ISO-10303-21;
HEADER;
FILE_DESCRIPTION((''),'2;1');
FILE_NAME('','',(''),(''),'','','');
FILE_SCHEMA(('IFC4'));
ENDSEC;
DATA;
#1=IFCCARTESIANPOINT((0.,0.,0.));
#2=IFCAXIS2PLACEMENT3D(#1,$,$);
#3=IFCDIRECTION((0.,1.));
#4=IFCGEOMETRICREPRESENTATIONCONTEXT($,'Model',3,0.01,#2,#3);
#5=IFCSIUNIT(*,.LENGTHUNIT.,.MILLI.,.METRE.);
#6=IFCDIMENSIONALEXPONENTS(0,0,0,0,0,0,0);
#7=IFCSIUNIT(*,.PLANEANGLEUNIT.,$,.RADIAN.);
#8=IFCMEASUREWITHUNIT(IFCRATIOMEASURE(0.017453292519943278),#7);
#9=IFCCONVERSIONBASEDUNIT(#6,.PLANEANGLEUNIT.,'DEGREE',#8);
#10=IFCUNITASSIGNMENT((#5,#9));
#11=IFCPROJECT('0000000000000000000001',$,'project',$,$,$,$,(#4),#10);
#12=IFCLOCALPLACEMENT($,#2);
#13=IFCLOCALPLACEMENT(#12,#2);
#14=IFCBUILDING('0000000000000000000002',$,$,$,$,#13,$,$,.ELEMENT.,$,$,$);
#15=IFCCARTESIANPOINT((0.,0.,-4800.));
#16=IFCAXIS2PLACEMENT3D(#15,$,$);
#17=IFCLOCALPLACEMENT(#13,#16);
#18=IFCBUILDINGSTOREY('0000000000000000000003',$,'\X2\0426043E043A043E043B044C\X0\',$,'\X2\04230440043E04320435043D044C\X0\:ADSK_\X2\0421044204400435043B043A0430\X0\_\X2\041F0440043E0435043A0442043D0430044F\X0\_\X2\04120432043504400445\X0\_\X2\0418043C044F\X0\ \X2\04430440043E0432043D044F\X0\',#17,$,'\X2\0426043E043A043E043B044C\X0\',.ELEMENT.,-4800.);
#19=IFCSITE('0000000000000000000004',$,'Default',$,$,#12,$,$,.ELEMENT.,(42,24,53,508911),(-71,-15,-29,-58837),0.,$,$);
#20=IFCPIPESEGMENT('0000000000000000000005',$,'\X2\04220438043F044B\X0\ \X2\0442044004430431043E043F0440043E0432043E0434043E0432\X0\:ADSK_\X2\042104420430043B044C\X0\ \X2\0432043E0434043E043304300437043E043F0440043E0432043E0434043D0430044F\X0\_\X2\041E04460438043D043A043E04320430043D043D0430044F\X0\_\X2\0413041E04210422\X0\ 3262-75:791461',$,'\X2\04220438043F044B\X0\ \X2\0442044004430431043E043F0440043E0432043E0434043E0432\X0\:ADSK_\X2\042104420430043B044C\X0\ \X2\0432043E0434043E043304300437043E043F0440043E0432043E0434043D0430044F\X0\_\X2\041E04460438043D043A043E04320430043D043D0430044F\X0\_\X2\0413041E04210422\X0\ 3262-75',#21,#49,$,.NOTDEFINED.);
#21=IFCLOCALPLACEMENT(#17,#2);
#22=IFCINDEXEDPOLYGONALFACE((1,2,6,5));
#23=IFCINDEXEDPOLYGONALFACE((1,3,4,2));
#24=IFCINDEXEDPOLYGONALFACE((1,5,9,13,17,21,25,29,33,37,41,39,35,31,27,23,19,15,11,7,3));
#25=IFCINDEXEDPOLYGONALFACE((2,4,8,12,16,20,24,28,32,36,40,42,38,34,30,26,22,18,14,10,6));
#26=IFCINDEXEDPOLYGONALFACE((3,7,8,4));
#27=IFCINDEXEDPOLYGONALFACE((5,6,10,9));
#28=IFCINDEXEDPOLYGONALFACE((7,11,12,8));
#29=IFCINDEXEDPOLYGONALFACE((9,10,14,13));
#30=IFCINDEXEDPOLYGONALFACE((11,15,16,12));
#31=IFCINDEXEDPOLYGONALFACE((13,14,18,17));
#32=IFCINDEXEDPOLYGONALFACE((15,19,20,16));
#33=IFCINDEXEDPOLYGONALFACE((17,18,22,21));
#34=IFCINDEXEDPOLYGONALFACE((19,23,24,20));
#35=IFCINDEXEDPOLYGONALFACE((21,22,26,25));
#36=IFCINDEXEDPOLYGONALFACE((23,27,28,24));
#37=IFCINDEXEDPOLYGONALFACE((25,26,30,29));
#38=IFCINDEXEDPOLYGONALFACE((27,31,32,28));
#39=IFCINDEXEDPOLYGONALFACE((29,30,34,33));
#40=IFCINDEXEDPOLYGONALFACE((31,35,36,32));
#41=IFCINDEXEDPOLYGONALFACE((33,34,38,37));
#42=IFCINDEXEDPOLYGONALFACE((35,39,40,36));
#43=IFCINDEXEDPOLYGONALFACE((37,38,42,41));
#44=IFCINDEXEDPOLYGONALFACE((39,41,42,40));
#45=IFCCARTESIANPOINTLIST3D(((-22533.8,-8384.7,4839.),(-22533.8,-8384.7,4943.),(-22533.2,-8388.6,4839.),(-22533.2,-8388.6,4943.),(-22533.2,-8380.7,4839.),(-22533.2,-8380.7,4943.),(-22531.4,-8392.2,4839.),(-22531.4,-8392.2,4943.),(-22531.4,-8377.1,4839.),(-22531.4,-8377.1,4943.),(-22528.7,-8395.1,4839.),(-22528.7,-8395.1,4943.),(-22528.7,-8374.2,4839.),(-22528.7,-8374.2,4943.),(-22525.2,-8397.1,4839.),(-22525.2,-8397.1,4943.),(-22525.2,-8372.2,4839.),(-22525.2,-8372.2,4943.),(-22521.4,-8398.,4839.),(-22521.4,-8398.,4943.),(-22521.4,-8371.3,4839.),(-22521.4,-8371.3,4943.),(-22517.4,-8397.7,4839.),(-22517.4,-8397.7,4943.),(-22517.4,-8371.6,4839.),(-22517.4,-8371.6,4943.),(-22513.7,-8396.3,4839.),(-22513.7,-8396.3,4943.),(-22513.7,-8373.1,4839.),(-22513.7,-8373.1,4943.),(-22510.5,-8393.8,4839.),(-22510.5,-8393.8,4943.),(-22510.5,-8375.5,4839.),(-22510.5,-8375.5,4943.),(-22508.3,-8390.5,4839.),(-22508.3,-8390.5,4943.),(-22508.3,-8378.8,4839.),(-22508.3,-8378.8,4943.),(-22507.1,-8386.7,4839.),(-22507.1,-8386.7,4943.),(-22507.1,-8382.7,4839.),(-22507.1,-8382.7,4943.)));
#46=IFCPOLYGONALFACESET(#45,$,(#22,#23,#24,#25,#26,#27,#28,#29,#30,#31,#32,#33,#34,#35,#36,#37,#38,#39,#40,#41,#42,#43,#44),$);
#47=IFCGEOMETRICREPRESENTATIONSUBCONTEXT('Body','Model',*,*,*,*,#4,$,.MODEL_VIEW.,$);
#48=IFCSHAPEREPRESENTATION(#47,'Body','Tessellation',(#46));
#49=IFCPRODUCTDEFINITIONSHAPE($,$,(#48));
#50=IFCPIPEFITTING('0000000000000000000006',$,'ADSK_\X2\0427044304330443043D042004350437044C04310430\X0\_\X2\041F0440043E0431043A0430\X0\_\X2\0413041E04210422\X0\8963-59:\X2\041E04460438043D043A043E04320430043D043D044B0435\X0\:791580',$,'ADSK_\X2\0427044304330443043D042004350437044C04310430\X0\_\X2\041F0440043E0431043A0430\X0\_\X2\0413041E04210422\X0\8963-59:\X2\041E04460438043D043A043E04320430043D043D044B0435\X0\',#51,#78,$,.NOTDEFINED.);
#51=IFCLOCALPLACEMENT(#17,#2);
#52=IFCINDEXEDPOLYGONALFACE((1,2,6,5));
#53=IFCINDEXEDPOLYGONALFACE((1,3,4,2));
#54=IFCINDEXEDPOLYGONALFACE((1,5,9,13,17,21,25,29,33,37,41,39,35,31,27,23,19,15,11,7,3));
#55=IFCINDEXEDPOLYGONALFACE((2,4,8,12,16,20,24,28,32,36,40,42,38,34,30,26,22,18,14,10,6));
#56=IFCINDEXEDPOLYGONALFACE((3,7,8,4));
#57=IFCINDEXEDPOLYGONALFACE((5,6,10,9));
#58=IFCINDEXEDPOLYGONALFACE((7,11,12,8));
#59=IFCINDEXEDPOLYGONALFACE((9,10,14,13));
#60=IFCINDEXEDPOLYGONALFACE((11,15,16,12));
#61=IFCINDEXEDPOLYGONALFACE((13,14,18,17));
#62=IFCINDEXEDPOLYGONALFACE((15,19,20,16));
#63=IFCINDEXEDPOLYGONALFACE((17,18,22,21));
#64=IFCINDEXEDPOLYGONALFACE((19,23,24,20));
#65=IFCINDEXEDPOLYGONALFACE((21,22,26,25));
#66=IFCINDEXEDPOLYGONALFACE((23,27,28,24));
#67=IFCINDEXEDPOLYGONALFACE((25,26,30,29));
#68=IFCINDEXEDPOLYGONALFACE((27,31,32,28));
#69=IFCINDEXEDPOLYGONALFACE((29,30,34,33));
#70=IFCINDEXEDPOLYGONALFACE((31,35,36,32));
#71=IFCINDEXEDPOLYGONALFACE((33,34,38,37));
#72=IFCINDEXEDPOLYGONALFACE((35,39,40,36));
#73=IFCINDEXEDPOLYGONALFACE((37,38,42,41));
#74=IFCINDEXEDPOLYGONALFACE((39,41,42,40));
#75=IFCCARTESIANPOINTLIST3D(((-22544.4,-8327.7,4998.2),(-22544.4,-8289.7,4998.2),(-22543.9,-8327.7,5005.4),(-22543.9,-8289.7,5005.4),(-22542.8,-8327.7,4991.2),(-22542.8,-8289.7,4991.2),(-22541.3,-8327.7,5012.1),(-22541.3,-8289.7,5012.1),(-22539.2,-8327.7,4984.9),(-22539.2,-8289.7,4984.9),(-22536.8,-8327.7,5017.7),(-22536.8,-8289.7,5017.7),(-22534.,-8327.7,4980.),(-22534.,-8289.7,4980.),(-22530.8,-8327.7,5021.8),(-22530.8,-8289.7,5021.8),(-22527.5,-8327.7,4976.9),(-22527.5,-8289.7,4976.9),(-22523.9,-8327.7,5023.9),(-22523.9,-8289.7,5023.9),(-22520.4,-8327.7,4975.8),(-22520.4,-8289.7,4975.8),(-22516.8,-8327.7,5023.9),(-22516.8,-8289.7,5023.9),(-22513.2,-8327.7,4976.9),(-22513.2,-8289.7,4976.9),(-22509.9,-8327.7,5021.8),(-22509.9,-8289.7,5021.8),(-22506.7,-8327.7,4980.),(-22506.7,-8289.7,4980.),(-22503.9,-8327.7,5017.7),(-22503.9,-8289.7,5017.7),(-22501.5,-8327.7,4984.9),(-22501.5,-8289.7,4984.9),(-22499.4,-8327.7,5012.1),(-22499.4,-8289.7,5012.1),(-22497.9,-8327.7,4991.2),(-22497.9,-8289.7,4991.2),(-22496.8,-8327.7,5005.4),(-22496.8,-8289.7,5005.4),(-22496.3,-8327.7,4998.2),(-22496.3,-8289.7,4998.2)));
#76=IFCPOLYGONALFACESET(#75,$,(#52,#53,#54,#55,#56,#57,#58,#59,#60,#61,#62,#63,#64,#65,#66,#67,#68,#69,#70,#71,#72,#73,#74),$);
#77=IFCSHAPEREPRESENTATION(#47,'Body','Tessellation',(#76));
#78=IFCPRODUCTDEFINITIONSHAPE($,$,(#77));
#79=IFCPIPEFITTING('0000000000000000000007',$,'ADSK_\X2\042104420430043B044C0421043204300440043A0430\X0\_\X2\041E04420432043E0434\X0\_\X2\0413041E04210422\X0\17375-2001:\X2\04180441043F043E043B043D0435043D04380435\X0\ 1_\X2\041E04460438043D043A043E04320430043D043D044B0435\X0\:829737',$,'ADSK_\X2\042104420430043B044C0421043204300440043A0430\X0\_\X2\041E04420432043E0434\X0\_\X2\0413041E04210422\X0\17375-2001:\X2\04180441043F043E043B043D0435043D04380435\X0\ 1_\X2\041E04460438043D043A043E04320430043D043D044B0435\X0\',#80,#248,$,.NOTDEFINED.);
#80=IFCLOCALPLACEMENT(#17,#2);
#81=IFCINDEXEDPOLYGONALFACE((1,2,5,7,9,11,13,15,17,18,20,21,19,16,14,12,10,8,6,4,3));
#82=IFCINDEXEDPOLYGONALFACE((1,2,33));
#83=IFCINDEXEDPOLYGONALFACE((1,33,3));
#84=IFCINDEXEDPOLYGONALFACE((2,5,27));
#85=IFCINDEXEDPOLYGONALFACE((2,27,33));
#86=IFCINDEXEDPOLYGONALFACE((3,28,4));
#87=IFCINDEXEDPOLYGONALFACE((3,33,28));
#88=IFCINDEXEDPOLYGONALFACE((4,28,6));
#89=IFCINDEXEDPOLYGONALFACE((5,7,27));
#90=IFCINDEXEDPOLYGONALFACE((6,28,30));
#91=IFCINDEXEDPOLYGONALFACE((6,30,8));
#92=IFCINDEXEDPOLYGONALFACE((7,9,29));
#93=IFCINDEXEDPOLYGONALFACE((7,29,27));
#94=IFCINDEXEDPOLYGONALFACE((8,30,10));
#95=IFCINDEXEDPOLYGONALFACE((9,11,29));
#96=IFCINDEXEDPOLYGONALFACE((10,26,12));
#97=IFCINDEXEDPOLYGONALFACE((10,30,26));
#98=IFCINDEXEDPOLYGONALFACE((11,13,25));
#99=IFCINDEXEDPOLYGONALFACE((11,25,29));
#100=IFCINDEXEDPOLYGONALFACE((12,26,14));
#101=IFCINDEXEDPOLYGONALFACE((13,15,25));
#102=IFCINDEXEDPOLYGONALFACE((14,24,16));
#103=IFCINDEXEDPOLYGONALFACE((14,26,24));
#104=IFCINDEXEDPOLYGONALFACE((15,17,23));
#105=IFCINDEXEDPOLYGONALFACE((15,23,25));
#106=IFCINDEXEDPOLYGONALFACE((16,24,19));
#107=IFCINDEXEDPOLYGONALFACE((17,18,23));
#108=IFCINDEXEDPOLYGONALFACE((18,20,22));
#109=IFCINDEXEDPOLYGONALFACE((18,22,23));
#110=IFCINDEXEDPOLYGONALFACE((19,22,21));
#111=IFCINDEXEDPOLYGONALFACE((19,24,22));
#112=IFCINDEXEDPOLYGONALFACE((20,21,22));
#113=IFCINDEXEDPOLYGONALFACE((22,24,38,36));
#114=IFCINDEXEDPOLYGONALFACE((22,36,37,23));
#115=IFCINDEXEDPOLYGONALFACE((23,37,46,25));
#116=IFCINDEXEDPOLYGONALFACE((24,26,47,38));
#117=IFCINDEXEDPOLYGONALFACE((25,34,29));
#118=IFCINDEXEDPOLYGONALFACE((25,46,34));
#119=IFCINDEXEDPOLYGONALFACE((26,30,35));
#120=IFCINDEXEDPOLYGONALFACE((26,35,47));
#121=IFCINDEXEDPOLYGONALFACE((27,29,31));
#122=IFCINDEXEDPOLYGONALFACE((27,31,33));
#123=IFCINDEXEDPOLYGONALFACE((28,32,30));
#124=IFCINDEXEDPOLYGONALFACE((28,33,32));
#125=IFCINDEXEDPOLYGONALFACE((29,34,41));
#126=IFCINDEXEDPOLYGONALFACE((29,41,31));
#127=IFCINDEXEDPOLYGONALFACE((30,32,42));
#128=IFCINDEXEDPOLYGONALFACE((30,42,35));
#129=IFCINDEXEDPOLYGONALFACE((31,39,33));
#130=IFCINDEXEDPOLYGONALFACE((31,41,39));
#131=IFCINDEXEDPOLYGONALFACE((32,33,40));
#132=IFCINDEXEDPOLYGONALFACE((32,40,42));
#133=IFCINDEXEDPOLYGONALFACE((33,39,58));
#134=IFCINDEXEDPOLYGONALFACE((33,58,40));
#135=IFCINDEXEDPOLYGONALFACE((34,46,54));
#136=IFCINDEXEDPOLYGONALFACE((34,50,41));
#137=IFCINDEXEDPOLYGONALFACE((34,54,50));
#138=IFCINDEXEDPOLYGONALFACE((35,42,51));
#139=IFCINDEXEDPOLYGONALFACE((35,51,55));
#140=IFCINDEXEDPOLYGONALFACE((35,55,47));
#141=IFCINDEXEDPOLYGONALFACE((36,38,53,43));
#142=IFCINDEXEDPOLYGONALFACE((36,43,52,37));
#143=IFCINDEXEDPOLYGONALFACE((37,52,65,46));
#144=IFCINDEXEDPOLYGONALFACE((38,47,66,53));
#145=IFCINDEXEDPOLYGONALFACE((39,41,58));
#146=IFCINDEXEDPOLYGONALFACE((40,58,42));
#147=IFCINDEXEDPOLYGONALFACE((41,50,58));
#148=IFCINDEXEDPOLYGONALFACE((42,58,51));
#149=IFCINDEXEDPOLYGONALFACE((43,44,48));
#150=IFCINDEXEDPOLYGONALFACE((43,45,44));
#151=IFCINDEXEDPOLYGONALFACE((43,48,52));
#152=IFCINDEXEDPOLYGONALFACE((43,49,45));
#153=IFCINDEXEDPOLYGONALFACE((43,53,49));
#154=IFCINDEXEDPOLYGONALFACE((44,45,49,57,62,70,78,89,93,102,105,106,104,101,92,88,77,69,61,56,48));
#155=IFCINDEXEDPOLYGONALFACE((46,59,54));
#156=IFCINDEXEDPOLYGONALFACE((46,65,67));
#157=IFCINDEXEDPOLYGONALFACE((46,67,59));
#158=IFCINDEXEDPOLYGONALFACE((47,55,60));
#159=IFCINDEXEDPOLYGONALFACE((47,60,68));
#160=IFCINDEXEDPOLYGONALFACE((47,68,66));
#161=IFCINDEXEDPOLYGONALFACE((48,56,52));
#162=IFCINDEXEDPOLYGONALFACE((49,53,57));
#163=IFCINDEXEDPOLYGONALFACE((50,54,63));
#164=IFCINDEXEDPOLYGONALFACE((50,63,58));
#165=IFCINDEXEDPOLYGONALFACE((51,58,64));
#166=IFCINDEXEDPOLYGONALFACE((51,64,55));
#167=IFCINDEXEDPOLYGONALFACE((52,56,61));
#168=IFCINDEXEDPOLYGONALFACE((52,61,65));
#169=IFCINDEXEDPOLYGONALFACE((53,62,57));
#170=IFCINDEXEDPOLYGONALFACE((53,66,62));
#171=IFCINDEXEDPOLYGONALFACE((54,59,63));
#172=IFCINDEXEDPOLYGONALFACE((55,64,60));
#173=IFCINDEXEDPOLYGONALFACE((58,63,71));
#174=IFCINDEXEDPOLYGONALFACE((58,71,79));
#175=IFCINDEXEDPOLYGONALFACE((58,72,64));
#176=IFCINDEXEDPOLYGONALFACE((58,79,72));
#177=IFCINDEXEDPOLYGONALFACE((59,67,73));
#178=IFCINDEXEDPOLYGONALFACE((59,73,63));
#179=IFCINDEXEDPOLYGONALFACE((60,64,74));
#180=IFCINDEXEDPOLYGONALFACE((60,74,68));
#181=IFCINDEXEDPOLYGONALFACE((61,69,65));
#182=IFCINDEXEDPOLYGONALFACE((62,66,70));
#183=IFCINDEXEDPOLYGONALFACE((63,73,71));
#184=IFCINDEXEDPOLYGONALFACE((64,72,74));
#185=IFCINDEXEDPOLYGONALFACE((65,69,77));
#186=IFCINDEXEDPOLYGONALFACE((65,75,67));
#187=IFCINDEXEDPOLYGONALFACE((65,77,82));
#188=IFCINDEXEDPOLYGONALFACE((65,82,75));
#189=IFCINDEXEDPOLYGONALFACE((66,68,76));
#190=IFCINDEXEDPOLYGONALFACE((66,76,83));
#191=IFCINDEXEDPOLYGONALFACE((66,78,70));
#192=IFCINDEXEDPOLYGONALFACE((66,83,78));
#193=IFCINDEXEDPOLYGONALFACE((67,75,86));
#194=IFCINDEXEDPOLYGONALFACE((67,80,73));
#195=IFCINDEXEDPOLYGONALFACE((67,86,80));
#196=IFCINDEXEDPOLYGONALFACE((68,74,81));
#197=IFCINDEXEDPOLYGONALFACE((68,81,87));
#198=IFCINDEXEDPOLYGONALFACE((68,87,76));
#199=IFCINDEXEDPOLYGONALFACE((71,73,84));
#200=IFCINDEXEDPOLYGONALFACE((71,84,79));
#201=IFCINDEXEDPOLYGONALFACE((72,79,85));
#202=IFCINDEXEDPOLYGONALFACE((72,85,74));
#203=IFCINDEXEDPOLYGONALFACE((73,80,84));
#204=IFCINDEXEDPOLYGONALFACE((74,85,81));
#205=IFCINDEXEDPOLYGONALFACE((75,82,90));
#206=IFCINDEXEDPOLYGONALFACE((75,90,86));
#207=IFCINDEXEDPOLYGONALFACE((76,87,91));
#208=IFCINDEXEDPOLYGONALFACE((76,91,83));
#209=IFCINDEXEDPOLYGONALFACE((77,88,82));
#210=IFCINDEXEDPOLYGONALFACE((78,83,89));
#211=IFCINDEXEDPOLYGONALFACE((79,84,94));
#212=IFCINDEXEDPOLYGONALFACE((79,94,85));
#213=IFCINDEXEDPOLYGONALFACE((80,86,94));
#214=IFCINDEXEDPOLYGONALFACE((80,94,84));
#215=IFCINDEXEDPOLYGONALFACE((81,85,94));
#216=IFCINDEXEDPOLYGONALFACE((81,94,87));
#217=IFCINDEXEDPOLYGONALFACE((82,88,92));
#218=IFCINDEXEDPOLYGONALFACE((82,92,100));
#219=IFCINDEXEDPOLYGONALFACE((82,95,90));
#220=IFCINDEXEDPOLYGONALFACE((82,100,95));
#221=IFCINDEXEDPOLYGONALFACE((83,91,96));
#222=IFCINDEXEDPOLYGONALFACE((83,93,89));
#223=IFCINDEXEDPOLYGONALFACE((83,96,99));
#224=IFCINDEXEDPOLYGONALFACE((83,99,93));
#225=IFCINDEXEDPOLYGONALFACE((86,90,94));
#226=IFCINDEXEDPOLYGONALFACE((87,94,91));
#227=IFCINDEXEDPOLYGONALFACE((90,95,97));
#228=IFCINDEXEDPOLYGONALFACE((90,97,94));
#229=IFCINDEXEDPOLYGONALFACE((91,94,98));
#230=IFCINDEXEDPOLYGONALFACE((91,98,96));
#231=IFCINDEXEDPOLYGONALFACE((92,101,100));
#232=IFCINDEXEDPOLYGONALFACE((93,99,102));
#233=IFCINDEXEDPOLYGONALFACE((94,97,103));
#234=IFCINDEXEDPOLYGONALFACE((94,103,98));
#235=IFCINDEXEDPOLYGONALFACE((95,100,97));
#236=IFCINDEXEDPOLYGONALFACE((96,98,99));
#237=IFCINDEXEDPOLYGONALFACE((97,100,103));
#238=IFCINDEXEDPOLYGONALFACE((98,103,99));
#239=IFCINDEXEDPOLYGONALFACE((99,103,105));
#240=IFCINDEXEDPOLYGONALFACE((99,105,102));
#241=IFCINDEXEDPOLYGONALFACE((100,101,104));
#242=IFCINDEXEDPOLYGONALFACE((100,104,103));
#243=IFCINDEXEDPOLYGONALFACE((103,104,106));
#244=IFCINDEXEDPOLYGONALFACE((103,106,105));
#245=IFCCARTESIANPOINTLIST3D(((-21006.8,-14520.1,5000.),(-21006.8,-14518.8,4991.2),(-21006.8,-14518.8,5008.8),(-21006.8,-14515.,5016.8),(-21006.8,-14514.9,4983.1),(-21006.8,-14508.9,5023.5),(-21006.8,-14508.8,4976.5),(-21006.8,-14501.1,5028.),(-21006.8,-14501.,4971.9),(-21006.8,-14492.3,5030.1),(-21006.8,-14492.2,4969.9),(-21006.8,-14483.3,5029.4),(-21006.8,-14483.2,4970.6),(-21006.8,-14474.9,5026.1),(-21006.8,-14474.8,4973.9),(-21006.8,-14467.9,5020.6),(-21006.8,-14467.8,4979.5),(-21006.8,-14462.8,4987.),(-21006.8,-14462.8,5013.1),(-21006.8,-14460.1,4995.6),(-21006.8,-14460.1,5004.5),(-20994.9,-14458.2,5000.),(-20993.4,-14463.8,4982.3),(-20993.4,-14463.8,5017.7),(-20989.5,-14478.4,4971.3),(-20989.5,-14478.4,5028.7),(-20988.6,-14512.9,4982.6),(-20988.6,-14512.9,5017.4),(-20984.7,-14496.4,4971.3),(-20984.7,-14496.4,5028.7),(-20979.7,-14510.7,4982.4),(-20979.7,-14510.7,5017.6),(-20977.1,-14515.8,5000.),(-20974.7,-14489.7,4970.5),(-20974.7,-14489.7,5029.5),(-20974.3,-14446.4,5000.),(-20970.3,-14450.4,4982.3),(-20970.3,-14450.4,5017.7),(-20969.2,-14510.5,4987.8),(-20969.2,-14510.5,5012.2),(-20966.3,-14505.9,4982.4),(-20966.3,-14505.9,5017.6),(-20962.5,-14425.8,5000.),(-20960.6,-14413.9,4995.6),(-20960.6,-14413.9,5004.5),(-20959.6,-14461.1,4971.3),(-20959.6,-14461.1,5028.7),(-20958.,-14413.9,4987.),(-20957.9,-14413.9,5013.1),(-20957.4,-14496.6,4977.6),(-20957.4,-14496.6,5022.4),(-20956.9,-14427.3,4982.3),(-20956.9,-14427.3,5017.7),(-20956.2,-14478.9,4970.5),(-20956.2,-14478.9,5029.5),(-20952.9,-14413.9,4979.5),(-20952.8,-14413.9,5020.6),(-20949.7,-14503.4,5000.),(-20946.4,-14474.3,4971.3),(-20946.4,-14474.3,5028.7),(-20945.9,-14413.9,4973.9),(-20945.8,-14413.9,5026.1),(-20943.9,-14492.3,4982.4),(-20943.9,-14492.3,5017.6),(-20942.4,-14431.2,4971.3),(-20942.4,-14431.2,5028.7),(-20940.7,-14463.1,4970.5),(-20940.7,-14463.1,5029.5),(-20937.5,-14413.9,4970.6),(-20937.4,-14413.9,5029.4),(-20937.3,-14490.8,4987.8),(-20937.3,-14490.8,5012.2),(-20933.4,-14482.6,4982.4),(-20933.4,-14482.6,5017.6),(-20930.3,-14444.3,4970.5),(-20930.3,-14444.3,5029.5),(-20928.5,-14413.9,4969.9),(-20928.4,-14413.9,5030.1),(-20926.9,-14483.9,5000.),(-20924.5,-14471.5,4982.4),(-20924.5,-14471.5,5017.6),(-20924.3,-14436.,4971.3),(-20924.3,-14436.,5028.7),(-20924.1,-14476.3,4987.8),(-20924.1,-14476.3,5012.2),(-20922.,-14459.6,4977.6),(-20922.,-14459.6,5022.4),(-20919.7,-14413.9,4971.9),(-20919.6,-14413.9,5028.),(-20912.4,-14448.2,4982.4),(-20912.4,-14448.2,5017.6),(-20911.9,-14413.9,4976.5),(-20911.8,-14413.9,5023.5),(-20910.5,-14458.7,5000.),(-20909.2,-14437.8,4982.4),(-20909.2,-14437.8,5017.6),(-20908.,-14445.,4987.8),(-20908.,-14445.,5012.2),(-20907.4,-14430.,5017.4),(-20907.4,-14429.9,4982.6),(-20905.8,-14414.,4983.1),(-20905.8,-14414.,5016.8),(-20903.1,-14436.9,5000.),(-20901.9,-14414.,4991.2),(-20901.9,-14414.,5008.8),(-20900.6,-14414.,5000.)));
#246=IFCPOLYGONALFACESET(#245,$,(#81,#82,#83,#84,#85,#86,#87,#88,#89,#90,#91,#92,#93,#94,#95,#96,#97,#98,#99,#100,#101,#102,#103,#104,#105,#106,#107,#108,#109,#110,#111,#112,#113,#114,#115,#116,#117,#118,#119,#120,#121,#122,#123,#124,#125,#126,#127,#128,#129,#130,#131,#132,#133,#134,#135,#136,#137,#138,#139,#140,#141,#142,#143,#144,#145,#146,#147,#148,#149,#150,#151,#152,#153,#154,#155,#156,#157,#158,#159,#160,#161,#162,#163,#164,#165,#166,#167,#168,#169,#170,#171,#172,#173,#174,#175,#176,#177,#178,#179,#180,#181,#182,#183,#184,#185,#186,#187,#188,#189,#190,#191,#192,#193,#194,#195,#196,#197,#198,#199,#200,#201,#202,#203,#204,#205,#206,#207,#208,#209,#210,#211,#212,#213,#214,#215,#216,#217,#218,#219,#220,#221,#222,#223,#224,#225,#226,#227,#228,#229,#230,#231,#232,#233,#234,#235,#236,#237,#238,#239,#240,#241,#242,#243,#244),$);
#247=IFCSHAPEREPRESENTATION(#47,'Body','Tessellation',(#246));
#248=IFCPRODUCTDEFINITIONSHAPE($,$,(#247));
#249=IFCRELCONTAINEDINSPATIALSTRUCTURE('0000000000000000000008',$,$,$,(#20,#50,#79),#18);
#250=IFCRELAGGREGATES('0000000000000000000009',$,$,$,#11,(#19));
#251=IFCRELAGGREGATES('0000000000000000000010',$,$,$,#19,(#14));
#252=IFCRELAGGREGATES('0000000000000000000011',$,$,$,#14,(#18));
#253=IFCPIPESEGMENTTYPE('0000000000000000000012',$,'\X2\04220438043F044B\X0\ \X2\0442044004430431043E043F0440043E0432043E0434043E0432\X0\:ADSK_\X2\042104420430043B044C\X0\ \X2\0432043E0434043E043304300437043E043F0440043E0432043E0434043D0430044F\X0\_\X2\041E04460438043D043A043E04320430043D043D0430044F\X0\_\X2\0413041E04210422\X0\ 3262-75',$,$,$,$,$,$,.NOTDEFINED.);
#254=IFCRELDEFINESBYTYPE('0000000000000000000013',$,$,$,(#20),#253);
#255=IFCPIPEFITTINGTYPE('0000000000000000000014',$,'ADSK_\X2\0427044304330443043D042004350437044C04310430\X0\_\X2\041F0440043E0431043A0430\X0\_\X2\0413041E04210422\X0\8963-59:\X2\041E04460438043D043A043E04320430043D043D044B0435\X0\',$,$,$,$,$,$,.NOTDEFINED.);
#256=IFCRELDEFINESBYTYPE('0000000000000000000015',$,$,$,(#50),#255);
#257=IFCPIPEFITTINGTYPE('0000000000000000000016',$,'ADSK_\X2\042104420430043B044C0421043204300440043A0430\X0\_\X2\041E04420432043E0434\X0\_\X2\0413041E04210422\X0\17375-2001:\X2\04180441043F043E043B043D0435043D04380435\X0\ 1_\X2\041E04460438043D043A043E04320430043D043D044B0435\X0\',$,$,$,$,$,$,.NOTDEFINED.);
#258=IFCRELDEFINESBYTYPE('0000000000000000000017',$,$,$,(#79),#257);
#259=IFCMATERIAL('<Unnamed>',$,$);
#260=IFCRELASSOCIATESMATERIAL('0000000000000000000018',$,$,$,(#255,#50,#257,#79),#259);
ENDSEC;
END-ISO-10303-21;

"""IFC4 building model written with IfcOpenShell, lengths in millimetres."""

from ifc_helpers import new_model, entity, si_unit, converted_unit, direction, frame, frame_2d, origin, place, context, subcontext, project, spatial, circle, extrude, source, transform, mapped, material, type_object, type_shapes, element, save


model = new_model("IFC4")

# Units and contexts
model_context = context("Model", 3, precision=0.01, world=origin(), true_north=direction((0.0, 1.0)))
body_context = subcontext(model_context, "Body", "Model", "MODEL_VIEW")
ifc_project = project(units=[si_unit("LENGTHUNIT", "METRE", prefix="MILLI"), converted_unit("PLANEANGLEUNIT", "DEGREE", entity("IfcRatioMeasure", 0.017453292519943278), si_unit("PLANEANGLEUNIT", "RADIAN"), dimensions=[0, 0, 0, 0, 0, 0, 0])], contexts=[model_context])

# Site, building, storey
site_placement = place(None, origin())
site = spatial("IfcSite", under=ifc_project, at=site_placement, Name="Default", CompositionType="ELEMENT", RefLatitude=(42, 24, 53, 508911), RefLongitude=(-71, -15, -29, -58837), RefElevation=0.0)
building_placement = place(site_placement, origin())
building = spatial("IfcBuilding", under=site, at=building_placement, CompositionType="ELEMENT")
storey_placement = place(building_placement, frame((0.0, 0.0, -4800.0)))
storey = spatial("IfcBuildingStorey", under=building, at=storey_placement, Name="Цоколь", ObjectType="Уровень:ADSK_Стрелка_Проектная_Вверх_Имя уровня", LongName="Цоколь", CompositionType="ELEMENT", Elevation=-4800.0)

# Shared definitions
ifc_material_1 = material(Name="<Unnamed>")

# Pipe segment
pipe_segment_type = type_object("IfcPipeSegmentType", Name="Типы трубопроводов:ADSK_Сталь водогазопроводная_Оцинкованная_ГОСТ 3262-75", PredefinedType="NOTDEFINED")
pipe_segment_1_placement = place(storey_placement, frame((-22535.3, -8399.7, 4943.0)))
element("IfcPipeSegment", 1, at=pipe_segment_1_placement, inside=storey, type_object=pipe_segment_type, Name="Типы трубопроводов:ADSK_Сталь водогазопроводная_Оцинкованная_ГОСТ 3262-75:791461", ObjectType="Типы трубопроводов:ADSK_Сталь водогазопроводная_Оцинкованная_ГОСТ 3262-75", PredefinedType="NOTDEFINED", context=body_context, shape_type="SweptSolid", body=[
    extrude(circle(Radius=13.4, at=frame_2d((0.0, 0.0), x_axis=(1.0, 0.0))), frame((15.0, 15.0, -104.0), z_axis=(0.0, 0.0, 1.0), x_axis=(-1.0, 0.0, 0.0)), (0.0, 0.0, 1.0), 104.0),
])

# Pipe fittings
pipe_fitting_type_1 = type_object("IfcPipeFittingType", Name="ADSK_ЧугунРезьба_Пробка_ГОСТ8963-59:Оцинкованные", PredefinedType="NOTDEFINED", material=ifc_material_1)
shared_shape_1 = source(origin(), body_context, "Body", "SweptSolid", [
    extrude(circle(Radius=24.1, at=frame_2d((0.0, 0.0), x_axis=(1.0, 0.0))), frame((0.0, 0.0, 0.0), z_axis=(1.0, 0.0, 0.0), x_axis=(0.0, 1.0, 0.0)), (0.0, 0.0, 1.0), 38.0),
])
type_shapes(pipe_fitting_type_1, [shared_shape_1])
pipe_fitting_1_placement = place(storey_placement, frame((-22520.4, -8327.7, 5000.0), z_axis=(-1.0, 0.0, 0.0), x_axis=(0.0, 1.0, 0.0)))
element("IfcPipeFitting", 2, at=pipe_fitting_1_placement, inside=storey, type_object=pipe_fitting_type_1, material=ifc_material_1, Name="ADSK_ЧугунРезьба_Пробка_ГОСТ8963-59:Оцинкованные:791580", ObjectType="ADSK_ЧугунРезьба_Пробка_ГОСТ8963-59:Оцинкованные", PredefinedType="NOTDEFINED", context=body_context, shape_type="MappedRepresentation", body=[
    mapped(shared_shape_1, transform((0.0, 0.0, 0.0), scale=1.0)),
])
pipe_fitting_type_2 = type_object("IfcPipeFittingType", Name="ADSK_СтальСварка_Отвод_ГОСТ17375-2001:Исполнение 1_Оцинкованные", PredefinedType="NOTDEFINED", material=ifc_material_1)
ifc_direction_1 = entity("IfcDirection", [0.0, 0.0, 1.0])
trimmed_curve_1 = entity("IfcTrimmedCurve", entity("IfcCircle", entity("IfcAxis2Placement2D", entity("IfcCartesianPoint", [-76.0, 0.0]), entity("IfcDirection", [0.0, 1.0])), 76.0), [entity("IfcParameterValue", 270.0)], [entity("IfcParameterValue", 0.0)], True, "PARAMETER")
shared_shape_2 = source(origin(), body_context, "Body", "AdvancedSweptSolid", [
    entity("IfcSurfaceCurveSweptAreaSolid", entity("IfcCircleProfileDef", "AREA", None, entity("IfcAxis2Placement2D", entity("IfcCartesianPoint", [0.0, 0.0]), entity("IfcDirection", [1.0, 0.0])), 30.1), entity("IfcAxis2Placement3D", entity("IfcCartesianPoint", [-76.0, 0.0, 0.0]), ifc_direction_1, entity("IfcDirection", [0.0, -1.0, 0.0])), trimmed_curve_1, 0.0, 90.0, entity("IfcSurfaceOfLinearExtrusion", entity("IfcArbitraryOpenProfileDef", "CURVE", None, trimmed_curve_1), entity("IfcAxis2Placement3D", entity("IfcCartesianPoint", [0.0, 0.0, -304.8])), ifc_direction_1, 1.0)),
])
type_shapes(pipe_fitting_type_2, [shared_shape_2])
pipe_fitting_2_placement = place(storey_placement, frame((-20930.8, -14489.9, 5000.0)))
element("IfcPipeFitting", 3, at=pipe_fitting_2_placement, inside=storey, type_object=pipe_fitting_type_2, material=ifc_material_1, Name="ADSK_СтальСварка_Отвод_ГОСТ17375-2001:Исполнение 1_Оцинкованные:829737", ObjectType="ADSK_СтальСварка_Отвод_ГОСТ17375-2001:Исполнение 1_Оцинкованные", PredefinedType="NOTDEFINED", context=body_context, shape_type="MappedRepresentation", body=[
    mapped(shared_shape_2, transform((0.0, 0.0, 0.0), scale=1.0)),
])

save(model, "model.ifc")
